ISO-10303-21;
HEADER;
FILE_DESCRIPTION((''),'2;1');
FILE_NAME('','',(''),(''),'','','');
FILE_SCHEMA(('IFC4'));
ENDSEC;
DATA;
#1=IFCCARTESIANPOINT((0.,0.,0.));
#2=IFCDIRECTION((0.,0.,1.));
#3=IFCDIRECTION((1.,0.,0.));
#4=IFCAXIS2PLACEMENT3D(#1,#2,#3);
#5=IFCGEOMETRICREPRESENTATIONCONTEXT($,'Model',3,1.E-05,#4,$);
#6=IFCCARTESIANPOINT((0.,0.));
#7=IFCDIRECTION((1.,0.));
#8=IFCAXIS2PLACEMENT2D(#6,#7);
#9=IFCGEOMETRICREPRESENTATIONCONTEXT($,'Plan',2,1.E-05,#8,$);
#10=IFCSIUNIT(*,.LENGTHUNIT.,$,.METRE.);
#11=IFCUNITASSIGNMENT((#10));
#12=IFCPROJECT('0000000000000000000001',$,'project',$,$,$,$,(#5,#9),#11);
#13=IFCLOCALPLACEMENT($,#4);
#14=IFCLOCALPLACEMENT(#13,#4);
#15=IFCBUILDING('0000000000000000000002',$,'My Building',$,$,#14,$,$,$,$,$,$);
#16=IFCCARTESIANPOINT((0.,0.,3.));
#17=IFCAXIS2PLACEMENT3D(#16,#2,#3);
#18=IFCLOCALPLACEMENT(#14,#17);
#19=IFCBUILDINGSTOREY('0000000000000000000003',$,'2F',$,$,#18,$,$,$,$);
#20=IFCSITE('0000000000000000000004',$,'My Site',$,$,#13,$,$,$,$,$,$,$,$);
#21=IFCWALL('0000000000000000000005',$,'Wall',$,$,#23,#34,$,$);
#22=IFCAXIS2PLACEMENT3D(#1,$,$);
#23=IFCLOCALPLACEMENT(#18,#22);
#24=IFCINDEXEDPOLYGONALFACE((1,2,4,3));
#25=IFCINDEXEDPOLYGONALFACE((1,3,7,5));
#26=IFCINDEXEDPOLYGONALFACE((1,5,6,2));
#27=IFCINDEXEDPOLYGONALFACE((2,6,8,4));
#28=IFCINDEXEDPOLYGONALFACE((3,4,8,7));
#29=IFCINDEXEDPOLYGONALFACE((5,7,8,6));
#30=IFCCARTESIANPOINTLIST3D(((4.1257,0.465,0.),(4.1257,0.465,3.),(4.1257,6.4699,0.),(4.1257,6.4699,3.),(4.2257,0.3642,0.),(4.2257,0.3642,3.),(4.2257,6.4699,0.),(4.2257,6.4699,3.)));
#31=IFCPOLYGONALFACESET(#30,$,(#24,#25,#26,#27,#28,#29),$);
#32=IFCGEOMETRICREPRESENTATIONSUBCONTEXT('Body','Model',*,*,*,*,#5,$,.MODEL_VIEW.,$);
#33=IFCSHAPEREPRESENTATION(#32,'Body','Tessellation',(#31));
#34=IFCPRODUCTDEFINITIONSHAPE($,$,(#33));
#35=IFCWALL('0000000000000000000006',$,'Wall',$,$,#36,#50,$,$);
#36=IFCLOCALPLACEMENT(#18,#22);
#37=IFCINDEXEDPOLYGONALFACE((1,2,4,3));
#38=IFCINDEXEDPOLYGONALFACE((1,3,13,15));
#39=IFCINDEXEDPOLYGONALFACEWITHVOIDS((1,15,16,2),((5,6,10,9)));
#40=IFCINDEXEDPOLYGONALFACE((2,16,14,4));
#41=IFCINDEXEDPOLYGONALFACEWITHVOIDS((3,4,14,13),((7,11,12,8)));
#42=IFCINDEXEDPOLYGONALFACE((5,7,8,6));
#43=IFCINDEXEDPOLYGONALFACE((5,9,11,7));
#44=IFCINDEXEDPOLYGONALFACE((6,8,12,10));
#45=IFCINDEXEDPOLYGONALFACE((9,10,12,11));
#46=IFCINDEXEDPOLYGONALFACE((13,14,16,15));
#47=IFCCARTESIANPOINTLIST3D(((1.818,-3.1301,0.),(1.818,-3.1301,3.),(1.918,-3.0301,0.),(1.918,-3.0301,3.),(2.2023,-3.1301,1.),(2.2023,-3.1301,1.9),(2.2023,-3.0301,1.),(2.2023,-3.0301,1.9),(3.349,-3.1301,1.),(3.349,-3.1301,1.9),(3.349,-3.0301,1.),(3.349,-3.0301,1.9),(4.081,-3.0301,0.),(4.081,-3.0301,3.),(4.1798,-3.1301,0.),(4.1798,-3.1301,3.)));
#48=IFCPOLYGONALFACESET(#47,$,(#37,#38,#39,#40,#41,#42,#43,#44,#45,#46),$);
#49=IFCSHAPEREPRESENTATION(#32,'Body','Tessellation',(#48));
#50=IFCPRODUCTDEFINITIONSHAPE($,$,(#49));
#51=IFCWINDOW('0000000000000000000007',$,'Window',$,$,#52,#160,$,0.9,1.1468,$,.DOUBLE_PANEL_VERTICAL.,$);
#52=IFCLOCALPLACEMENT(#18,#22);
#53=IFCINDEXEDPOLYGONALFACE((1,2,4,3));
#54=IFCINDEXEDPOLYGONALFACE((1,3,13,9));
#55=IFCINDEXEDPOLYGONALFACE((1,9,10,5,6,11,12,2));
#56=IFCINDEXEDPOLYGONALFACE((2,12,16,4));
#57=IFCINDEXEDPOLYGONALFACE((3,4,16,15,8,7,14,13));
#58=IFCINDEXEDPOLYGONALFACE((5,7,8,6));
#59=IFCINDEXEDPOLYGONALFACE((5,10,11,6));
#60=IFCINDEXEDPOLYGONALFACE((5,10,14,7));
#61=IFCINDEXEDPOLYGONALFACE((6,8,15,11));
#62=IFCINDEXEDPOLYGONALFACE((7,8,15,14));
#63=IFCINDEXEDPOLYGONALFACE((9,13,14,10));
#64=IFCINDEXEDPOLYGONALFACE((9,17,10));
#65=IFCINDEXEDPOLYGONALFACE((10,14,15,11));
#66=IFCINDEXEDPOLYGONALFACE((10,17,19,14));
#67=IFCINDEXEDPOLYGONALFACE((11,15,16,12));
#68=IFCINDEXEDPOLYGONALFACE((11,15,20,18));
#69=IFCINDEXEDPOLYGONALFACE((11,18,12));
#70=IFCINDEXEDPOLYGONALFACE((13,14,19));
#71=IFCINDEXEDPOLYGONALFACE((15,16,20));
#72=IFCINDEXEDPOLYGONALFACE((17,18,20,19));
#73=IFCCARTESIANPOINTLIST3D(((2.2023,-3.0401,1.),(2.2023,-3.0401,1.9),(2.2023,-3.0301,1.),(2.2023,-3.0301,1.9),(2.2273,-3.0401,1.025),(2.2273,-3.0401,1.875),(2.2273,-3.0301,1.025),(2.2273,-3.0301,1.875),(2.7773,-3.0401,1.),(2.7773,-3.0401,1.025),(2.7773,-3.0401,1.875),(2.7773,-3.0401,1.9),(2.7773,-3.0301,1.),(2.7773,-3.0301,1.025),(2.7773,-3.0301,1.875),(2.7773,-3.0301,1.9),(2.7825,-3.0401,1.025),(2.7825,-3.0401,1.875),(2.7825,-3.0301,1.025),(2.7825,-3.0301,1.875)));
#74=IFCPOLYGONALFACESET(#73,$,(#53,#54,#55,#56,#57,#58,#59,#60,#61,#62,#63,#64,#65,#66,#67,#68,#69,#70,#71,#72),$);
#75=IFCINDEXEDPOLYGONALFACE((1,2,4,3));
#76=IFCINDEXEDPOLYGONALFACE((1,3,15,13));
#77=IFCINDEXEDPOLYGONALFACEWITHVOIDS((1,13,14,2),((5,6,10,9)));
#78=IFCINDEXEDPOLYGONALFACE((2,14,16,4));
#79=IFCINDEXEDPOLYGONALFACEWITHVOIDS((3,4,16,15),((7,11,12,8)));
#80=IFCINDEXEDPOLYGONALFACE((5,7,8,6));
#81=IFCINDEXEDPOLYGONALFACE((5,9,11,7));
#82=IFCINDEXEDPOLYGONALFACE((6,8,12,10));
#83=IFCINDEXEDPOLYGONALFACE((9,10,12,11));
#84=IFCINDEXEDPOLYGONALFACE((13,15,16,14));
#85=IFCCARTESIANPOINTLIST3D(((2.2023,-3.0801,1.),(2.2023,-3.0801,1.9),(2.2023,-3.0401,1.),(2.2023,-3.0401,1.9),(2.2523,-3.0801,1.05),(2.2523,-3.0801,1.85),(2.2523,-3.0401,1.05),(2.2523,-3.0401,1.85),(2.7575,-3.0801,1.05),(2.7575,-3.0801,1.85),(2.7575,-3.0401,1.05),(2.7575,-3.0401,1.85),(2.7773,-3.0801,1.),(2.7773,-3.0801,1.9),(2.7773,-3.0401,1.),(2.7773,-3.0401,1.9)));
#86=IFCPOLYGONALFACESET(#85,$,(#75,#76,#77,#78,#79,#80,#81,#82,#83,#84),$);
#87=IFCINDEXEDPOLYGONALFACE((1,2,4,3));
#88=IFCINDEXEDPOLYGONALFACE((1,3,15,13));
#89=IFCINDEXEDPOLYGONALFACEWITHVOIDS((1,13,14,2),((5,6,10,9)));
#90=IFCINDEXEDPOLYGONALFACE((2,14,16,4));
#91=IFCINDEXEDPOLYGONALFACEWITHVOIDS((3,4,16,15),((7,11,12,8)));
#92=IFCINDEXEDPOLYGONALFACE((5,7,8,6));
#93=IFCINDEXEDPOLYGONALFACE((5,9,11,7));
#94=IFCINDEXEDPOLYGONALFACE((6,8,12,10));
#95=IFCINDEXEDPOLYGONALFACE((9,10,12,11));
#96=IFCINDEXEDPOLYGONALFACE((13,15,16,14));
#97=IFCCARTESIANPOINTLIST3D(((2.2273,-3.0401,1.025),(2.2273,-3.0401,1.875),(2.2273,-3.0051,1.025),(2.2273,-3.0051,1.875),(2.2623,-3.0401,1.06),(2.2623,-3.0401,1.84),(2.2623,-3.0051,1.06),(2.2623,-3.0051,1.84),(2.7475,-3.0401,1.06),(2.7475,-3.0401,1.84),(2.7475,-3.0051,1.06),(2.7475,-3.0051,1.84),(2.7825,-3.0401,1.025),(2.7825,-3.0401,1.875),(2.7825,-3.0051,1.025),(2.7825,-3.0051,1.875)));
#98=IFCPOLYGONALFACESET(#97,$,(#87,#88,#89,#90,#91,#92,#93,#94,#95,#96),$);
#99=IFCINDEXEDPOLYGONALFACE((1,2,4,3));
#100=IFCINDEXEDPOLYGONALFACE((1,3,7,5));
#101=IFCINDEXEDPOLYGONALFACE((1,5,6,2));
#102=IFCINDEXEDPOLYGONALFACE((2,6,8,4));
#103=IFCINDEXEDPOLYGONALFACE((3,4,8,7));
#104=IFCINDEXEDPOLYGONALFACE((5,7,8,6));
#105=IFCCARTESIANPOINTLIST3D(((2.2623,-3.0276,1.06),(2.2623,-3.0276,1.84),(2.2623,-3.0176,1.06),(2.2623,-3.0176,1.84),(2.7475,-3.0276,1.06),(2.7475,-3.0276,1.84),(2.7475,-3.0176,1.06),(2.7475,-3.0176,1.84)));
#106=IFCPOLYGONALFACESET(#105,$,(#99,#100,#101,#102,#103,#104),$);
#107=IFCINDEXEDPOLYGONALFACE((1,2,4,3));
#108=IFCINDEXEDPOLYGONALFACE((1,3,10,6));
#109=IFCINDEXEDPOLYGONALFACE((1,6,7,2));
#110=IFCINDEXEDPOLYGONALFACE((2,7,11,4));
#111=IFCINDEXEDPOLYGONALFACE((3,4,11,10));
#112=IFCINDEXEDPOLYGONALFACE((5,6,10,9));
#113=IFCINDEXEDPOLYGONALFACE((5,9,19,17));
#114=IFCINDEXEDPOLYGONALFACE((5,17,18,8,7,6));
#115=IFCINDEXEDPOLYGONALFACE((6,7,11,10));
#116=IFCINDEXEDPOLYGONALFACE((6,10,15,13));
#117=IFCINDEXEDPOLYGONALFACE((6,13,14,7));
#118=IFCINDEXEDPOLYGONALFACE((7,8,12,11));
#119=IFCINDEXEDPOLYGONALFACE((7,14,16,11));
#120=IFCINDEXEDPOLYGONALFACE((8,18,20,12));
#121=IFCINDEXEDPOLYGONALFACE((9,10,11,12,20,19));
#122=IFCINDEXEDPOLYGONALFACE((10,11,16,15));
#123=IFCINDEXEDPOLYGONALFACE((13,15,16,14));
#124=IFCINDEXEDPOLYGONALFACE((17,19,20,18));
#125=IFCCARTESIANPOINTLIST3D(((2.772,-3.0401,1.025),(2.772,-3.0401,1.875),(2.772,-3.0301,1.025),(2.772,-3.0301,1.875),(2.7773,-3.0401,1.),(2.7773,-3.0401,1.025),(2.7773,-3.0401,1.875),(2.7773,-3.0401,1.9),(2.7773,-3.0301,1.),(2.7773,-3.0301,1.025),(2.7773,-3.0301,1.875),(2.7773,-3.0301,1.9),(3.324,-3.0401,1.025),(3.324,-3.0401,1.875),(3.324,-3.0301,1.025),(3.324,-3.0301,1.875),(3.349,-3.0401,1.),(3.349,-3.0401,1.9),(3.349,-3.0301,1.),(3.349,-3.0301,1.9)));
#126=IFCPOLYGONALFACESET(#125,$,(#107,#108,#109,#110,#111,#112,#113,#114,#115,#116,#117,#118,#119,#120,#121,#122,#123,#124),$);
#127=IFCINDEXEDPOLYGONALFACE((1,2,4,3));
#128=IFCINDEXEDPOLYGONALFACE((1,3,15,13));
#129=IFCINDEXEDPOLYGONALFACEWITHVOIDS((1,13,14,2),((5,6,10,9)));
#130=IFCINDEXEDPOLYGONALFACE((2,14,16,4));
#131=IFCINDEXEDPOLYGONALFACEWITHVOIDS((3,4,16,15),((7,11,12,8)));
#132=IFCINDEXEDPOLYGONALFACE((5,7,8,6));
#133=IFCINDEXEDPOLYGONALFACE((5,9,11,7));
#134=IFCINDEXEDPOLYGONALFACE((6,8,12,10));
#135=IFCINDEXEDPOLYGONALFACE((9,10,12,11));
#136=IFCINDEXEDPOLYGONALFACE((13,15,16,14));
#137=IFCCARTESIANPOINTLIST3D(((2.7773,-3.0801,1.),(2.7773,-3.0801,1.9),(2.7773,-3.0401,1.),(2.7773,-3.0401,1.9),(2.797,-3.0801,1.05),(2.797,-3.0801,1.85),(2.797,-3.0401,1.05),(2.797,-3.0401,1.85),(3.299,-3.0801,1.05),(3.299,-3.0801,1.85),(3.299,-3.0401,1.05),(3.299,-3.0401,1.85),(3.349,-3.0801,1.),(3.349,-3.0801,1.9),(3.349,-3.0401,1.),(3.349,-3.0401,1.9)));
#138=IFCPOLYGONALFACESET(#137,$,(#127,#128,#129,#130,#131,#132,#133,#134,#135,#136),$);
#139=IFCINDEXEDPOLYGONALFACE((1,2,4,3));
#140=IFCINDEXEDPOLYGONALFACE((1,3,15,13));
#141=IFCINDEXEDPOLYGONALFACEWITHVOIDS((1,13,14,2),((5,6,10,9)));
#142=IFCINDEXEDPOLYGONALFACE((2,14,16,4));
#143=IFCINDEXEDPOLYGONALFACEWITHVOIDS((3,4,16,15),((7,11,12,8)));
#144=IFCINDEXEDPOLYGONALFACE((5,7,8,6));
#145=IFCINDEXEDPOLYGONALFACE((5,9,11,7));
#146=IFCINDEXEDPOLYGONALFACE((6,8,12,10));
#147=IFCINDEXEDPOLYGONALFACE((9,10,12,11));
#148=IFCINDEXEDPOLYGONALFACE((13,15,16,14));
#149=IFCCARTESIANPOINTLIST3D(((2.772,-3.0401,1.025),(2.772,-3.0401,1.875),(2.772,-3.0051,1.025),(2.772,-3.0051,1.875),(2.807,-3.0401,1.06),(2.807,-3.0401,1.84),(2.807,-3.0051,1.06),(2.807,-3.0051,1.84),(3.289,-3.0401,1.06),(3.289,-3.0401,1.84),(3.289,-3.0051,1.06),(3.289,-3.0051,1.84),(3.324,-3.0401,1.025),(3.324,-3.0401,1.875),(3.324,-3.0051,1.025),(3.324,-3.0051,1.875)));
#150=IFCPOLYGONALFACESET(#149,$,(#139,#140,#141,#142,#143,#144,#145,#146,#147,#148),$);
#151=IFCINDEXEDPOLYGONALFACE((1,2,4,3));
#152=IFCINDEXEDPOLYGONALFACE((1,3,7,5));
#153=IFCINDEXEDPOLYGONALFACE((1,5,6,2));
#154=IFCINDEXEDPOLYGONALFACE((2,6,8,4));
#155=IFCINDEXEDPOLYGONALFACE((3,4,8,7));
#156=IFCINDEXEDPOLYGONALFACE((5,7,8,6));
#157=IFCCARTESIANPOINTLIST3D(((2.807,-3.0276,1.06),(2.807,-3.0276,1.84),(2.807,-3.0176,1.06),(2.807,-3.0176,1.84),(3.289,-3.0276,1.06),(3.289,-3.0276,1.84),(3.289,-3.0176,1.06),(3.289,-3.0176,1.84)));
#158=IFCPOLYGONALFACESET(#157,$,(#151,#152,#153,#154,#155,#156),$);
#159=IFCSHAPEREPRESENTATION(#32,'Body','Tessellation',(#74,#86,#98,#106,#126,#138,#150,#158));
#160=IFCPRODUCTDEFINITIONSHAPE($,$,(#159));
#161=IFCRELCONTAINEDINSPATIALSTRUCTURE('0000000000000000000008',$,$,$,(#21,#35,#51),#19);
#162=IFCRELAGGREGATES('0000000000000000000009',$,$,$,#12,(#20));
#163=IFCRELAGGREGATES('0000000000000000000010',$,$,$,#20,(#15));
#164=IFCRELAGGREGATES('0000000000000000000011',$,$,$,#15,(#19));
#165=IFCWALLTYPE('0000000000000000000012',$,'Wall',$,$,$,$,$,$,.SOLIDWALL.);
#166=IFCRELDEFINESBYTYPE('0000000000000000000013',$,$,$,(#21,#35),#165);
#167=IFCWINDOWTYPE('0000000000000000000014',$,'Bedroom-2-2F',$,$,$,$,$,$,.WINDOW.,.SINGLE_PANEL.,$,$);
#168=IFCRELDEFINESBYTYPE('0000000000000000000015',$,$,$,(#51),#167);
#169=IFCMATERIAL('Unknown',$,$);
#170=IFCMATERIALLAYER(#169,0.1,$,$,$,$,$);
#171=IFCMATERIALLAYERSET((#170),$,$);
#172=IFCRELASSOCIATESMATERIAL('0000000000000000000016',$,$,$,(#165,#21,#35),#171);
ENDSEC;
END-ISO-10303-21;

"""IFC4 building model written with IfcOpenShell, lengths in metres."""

from ifc_helpers import new_model, entity, si_unit, frame, origin_with_axes, origin_2d_with_axis, place, context, subcontext, project, spatial, line, indexed_curve, outline, extrude, shape, source, transform, mapped, material, layer, layer_set, layer_usage, type_object, type_shapes, element, fill, save


model = new_model("IFC4")

# Units and contexts
model_context = context("Model", 3, precision=1e-05, world=origin_with_axes())
plan_context = context("Plan", 2, precision=1e-05, world=origin_2d_with_axis())
body_context_1 = subcontext(model_context, "Body", "Model", "MODEL_VIEW")
body_context_2 = subcontext(plan_context, "Body", "Plan", "PLAN_VIEW")
ifc_project = project(units=[si_unit("LENGTHUNIT", "METRE")], contexts=[model_context, plan_context])

# Site, building, storey
site_placement = place(None, origin_with_axes())
site = spatial("IfcSite", under=ifc_project, at=site_placement, Name="My Site")
building_placement = place(site_placement, origin_with_axes())
building = spatial("IfcBuilding", under=site, at=building_placement, Name="My Building")
storey_placement = place(building_placement, frame((0.0, 0.0, 3.0), z_axis=(0.0, 0.0, 1.0), x_axis=(1.0, 0.0, 0.0)))
storey = spatial("IfcBuildingStorey", under=building, at=storey_placement, Name="2F")

# Shared definitions
ifc_material = material(Name="Unknown")
ifc_layer = layer(ifc_material, 0.1)
ifc_layer_set = layer_set([ifc_layer])
wall_type = type_object("IfcWallType", Name="Wall", PredefinedType="SOLIDWALL", material=ifc_layer_set)

# Wall
ifc_layer_usage_1 = layer_usage(ifc_layer_set, "AXIS2", "POSITIVE", 0.0)
wall_1_placement = place(storey_placement, frame((4.2257, 0.3642, 0.0), z_axis=(0.0, 0.0, 1.0), x_axis=(0.0, 1.0, 0.0)))
element("IfcWall", 1, at=wall_1_placement, inside=storey, type_object=wall_type, material=ifc_layer_usage_1, Name="Wall", context=body_context_1, shape_type="SweptSolid", body=[
    extrude(outline(indexed_curve([(0.0, 0.0), (0.1007, 0.1), (6.1056, 0.1), (6.1056, 0.0)], segments=[line(1, 2, 3, 4, 1)])), origin_with_axes(), (0.0, 0.0, 1.0), 3.0),
])

# Wall, opening, window
ifc_layer_usage_2 = layer_usage(ifc_layer_set, "AXIS2", "POSITIVE", 0.0)
wall_2_placement = place(storey_placement, frame((1.818, -3.1301, 0.0), z_axis=(0.0, 0.0, 1.0), x_axis=(1.0, 0.0, 0.0)))
wall_2 = element("IfcWall", 2, at=wall_2_placement, inside=storey, type_object=wall_type, material=ifc_layer_usage_2, Name="Wall", context=body_context_1, shape_type="SweptSolid", body=[
    extrude(outline(indexed_curve([(0.0, 0.0), (0.0999, 0.1), (2.2629, 0.1), (2.3618, 0.0)], segments=[line(1, 2, 3, 4, 1)])), origin_with_axes(), (0.0, 0.0, 1.0), 3.0),
])
shared_shape_1 = source(origin_with_axes(), body_context_1, "Body", "SweptSolid", [
    extrude(outline(indexed_curve([(0.0, 0.0), (1.1468, 0.0), (1.1468, 0.9), (0.0, 0.9)], segments=[line(1, 2, 3, 4, 1)])), frame((0.0, -0.6, 0.0), z_axis=(0.0, -1.0, 0.0), x_axis=(1.0, 0.0, 0.0)), (0.0, 0.0, -1.0), 1.2),
])
opening_1_placement = place(wall_2_placement, frame((0.3842, 0.0, 1.0), z_axis=(0.0, 0.0, 1.0), x_axis=(1.0, 0.0, 0.0)))
opening_1 = element("IfcOpeningElement", 3, at=opening_1_placement, cuts=wall_2, PredefinedType="OPENING", context=body_context_1, shape_type="MappedRepresentation", body=[
    mapped(shared_shape_1, transform((0.0, 0.0, 0.0), x_axis=(1.0, 0.0, 0.0), y_axis=(0.0, 1.0, 0.0), z_axis=(0.0, 0.0, 1.0), scale=1.0)),
])
window_type_1 = type_object("IfcWindowType", Name="Bedroom-2-2F", PartitioningType="SINGLE_PANEL", PredefinedType="WINDOW")
shared_shape_2 = source(origin_with_axes(), body_context_1, "Body", "SweptSolid", [
    extrude(outline(indexed_curve([(0.0, 0.0), (0.575, 0.0), (0.575, 0.9), (0.0, 0.9)], segments=[line(1, 2, 3, 4, 1)]), holes=[indexed_curve([(0.025, 0.025), (0.5803, 0.025), (0.5803, 0.875), (0.025, 0.875)], segments=[line(1, 2, 3, 4, 1)])]), frame((0.0, 0.09, 0.0), z_axis=(0.0, -1.0, 0.0), x_axis=(1.0, 0.0, 0.0)), (0.0, 0.0, -1.0), 0.01),
    extrude(outline(indexed_curve([(0.0, 0.0), (0.575, 0.0), (0.575, 0.9), (0.0, 0.9)], segments=[line(1, 2, 3, 4, 1)]), holes=[indexed_curve([(0.05, 0.05), (0.5553, 0.05), (0.5553, 0.85), (0.05, 0.85)], segments=[line(1, 2, 3, 4, 1)])]), frame((0.0, 0.05, 0.0), z_axis=(0.0, -1.0, 0.0), x_axis=(1.0, 0.0, 0.0)), (0.0, 0.0, -1.0), 0.04),
    extrude(outline(indexed_curve([(0.0, 0.0), (0.5553, 0.0), (0.5553, 0.85), (0.0, 0.85)], segments=[line(1, 2, 3, 4, 1)]), holes=[indexed_curve([(0.035, 0.035), (0.5203, 0.035), (0.5203, 0.815), (0.035, 0.815)], segments=[line(1, 2, 3, 4, 1)])]), frame((0.025, 0.09, 0.025), z_axis=(0.0, -1.0, 0.0), x_axis=(1.0, 0.0, 0.0)), (0.0, 0.0, -1.0), 0.035),
    extrude(outline(indexed_curve([(0.035, 0.035), (0.5203, 0.035), (0.5203, 0.815), (0.035, 0.815)], segments=[line(1, 2, 3, 4, 1)])), frame((0.025, 0.1025, 0.025), z_axis=(0.0, -1.0, 0.0), x_axis=(1.0, 0.0, 0.0)), (0.0, 0.0, -1.0), 0.01),
    extrude(outline(indexed_curve([(0.0, 0.0), (0.5718, 0.0), (0.5718, 0.9), (0.0, 0.9)], segments=[line(1, 2, 3, 4, 1)]), holes=[indexed_curve([(-0.0052, 0.025), (0.5468, 0.025), (0.5468, 0.875), (-0.0052, 0.875)], segments=[line(1, 2, 3, 4, 1)])]), frame((0.575, 0.09, 0.0), z_axis=(0.0, -1.0, 0.0), x_axis=(1.0, 0.0, 0.0)), (0.0, 0.0, -1.0), 0.01),
    extrude(outline(indexed_curve([(0.0, 0.0), (0.5718, 0.0), (0.5718, 0.9), (0.0, 0.9)], segments=[line(1, 2, 3, 4, 1)]), holes=[indexed_curve([(0.0198, 0.05), (0.5218, 0.05), (0.5218, 0.85), (0.0198, 0.85)], segments=[line(1, 2, 3, 4, 1)])]), frame((0.575, 0.05, 0.0), z_axis=(0.0, -1.0, 0.0), x_axis=(1.0, 0.0, 0.0)), (0.0, 0.0, -1.0), 0.04),
    extrude(outline(indexed_curve([(0.0, 0.0), (0.552, 0.0), (0.552, 0.85), (0.0, 0.85)], segments=[line(1, 2, 3, 4, 1)]), holes=[indexed_curve([(0.035, 0.035), (0.517, 0.035), (0.517, 0.815), (0.035, 0.815)], segments=[line(1, 2, 3, 4, 1)])]), frame((0.5698, 0.09, 0.025), z_axis=(0.0, -1.0, 0.0), x_axis=(1.0, 0.0, 0.0)), (0.0, 0.0, -1.0), 0.035),
    extrude(outline(indexed_curve([(0.035, 0.035), (0.517, 0.035), (0.517, 0.815), (0.035, 0.815)], segments=[line(1, 2, 3, 4, 1)])), frame((0.5698, 0.1025, 0.025), z_axis=(0.0, -1.0, 0.0), x_axis=(1.0, 0.0, 0.0)), (0.0, 0.0, -1.0), 0.01),
])
shared_shape_3 = source(origin_with_axes(), body_context_2, "Body", "Curve2D", [
    entity("IfcIndexedPolyCurve", entity("IfcCartesianPointList2D", [[0.05, 0.05], [0.5553, 0.05]])),
    entity("IfcIndexedPolyCurve", entity("IfcCartesianPointList2D", [[0.0, 0.1], [0.025, 0.1], [0.025, 0.09], [0.05, 0.09], [0.05, 0.05], [0.0, 0.05]]), [entity("IfcLineIndex", [1, 2, 3, 4, 5, 6, 1])]),
    entity("IfcIndexedPolyCurve", entity("IfcCartesianPointList2D", [[0.575, 0.1], [0.5803, 0.1], [0.5803, 0.09], [0.5553, 0.09], [0.5553, 0.05], [0.575, 0.05]])),
    entity("IfcIndexedPolyCurve", entity("IfcCartesianPointList2D", [[0.025, 0.09], [0.06, 0.09], [0.06, 0.125], [0.025, 0.125]]), [entity("IfcLineIndex", [1, 2, 3, 4, 1])]),
    entity("IfcIndexedPolyCurve", entity("IfcCartesianPointList2D", [[0.5803, 0.09], [0.5453, 0.09], [0.5453, 0.125], [0.5803, 0.125]]), [entity("IfcLineIndex", [1, 2, 3, 4, 1])]),
    entity("IfcIndexedPolyCurve", entity("IfcCartesianPointList2D", [[0.06, 0.09], [0.5453, 0.09]])),
    entity("IfcIndexedPolyCurve", entity("IfcCartesianPointList2D", [[0.06, 0.125], [0.5453, 0.125]])),
    entity("IfcIndexedPolyCurve", entity("IfcCartesianPointList2D", [[0.06, 0.1075], [0.5453, 0.1075]])),
    entity("IfcIndexedPolyCurve", entity("IfcCartesianPointList2D", [[0.5948, 0.05], [1.0968, 0.05]])),
    entity("IfcIndexedPolyCurve", entity("IfcCartesianPointList2D", [[0.575, 0.1], [0.5698, 0.1], [0.5698, 0.09], [0.5948, 0.09], [0.5948, 0.05], [0.575, 0.05]])),
    entity("IfcIndexedPolyCurve", entity("IfcCartesianPointList2D", [[1.1468, 0.1], [1.1218, 0.1], [1.1218, 0.09], [1.0968, 0.09], [1.0968, 0.05], [1.1468, 0.05]]), [entity("IfcLineIndex", [1, 2, 3, 4, 5, 6, 1])]),
    entity("IfcIndexedPolyCurve", entity("IfcCartesianPointList2D", [[0.5698, 0.09], [0.6048, 0.09], [0.6048, 0.125], [0.5698, 0.125]]), [entity("IfcLineIndex", [1, 2, 3, 4, 1])]),
    entity("IfcIndexedPolyCurve", entity("IfcCartesianPointList2D", [[1.1218, 0.09], [1.0868, 0.09], [1.0868, 0.125], [1.1218, 0.125]]), [entity("IfcLineIndex", [1, 2, 3, 4, 1])]),
    entity("IfcIndexedPolyCurve", entity("IfcCartesianPointList2D", [[0.6048, 0.09], [1.0868, 0.09]])),
    entity("IfcIndexedPolyCurve", entity("IfcCartesianPointList2D", [[0.6048, 0.125], [1.0868, 0.125]])),
    entity("IfcIndexedPolyCurve", entity("IfcCartesianPointList2D", [[0.6048, 0.1075], [1.0868, 0.1075]])),
])
type_shapes(window_type_1, [shared_shape_2, shared_shape_3])
window_1_placement = place(opening_1_placement, origin_with_axes())
window_1 = element("IfcWindow", 4, at=window_1_placement, inside=storey, type_object=window_type_1, Name="Window", OverallHeight=0.9, OverallWidth=1.1468, PartitioningType="DOUBLE_PANEL_VERTICAL", shapes=[
    shape(body_context_1, "Body", "MappedRepresentation", [mapped(shared_shape_2, transform((0.0, 0.0, 0.0), x_axis=(1.0, 0.0, 0.0), y_axis=(0.0, 1.0, 0.0), z_axis=(0.0, 0.0, 1.0), scale=1.0))]),
    shape(body_context_2, "Body", "MappedRepresentation", [mapped(shared_shape_3, transform((0.0, 0.0, 0.0), x_axis=(1.0, 0.0, 0.0), y_axis=(0.0, 1.0, 0.0), z_axis=(0.0, 0.0, 1.0), scale=1.0))]),
])
fill(opening_1, window_1)

save(model, "model.ifc")
